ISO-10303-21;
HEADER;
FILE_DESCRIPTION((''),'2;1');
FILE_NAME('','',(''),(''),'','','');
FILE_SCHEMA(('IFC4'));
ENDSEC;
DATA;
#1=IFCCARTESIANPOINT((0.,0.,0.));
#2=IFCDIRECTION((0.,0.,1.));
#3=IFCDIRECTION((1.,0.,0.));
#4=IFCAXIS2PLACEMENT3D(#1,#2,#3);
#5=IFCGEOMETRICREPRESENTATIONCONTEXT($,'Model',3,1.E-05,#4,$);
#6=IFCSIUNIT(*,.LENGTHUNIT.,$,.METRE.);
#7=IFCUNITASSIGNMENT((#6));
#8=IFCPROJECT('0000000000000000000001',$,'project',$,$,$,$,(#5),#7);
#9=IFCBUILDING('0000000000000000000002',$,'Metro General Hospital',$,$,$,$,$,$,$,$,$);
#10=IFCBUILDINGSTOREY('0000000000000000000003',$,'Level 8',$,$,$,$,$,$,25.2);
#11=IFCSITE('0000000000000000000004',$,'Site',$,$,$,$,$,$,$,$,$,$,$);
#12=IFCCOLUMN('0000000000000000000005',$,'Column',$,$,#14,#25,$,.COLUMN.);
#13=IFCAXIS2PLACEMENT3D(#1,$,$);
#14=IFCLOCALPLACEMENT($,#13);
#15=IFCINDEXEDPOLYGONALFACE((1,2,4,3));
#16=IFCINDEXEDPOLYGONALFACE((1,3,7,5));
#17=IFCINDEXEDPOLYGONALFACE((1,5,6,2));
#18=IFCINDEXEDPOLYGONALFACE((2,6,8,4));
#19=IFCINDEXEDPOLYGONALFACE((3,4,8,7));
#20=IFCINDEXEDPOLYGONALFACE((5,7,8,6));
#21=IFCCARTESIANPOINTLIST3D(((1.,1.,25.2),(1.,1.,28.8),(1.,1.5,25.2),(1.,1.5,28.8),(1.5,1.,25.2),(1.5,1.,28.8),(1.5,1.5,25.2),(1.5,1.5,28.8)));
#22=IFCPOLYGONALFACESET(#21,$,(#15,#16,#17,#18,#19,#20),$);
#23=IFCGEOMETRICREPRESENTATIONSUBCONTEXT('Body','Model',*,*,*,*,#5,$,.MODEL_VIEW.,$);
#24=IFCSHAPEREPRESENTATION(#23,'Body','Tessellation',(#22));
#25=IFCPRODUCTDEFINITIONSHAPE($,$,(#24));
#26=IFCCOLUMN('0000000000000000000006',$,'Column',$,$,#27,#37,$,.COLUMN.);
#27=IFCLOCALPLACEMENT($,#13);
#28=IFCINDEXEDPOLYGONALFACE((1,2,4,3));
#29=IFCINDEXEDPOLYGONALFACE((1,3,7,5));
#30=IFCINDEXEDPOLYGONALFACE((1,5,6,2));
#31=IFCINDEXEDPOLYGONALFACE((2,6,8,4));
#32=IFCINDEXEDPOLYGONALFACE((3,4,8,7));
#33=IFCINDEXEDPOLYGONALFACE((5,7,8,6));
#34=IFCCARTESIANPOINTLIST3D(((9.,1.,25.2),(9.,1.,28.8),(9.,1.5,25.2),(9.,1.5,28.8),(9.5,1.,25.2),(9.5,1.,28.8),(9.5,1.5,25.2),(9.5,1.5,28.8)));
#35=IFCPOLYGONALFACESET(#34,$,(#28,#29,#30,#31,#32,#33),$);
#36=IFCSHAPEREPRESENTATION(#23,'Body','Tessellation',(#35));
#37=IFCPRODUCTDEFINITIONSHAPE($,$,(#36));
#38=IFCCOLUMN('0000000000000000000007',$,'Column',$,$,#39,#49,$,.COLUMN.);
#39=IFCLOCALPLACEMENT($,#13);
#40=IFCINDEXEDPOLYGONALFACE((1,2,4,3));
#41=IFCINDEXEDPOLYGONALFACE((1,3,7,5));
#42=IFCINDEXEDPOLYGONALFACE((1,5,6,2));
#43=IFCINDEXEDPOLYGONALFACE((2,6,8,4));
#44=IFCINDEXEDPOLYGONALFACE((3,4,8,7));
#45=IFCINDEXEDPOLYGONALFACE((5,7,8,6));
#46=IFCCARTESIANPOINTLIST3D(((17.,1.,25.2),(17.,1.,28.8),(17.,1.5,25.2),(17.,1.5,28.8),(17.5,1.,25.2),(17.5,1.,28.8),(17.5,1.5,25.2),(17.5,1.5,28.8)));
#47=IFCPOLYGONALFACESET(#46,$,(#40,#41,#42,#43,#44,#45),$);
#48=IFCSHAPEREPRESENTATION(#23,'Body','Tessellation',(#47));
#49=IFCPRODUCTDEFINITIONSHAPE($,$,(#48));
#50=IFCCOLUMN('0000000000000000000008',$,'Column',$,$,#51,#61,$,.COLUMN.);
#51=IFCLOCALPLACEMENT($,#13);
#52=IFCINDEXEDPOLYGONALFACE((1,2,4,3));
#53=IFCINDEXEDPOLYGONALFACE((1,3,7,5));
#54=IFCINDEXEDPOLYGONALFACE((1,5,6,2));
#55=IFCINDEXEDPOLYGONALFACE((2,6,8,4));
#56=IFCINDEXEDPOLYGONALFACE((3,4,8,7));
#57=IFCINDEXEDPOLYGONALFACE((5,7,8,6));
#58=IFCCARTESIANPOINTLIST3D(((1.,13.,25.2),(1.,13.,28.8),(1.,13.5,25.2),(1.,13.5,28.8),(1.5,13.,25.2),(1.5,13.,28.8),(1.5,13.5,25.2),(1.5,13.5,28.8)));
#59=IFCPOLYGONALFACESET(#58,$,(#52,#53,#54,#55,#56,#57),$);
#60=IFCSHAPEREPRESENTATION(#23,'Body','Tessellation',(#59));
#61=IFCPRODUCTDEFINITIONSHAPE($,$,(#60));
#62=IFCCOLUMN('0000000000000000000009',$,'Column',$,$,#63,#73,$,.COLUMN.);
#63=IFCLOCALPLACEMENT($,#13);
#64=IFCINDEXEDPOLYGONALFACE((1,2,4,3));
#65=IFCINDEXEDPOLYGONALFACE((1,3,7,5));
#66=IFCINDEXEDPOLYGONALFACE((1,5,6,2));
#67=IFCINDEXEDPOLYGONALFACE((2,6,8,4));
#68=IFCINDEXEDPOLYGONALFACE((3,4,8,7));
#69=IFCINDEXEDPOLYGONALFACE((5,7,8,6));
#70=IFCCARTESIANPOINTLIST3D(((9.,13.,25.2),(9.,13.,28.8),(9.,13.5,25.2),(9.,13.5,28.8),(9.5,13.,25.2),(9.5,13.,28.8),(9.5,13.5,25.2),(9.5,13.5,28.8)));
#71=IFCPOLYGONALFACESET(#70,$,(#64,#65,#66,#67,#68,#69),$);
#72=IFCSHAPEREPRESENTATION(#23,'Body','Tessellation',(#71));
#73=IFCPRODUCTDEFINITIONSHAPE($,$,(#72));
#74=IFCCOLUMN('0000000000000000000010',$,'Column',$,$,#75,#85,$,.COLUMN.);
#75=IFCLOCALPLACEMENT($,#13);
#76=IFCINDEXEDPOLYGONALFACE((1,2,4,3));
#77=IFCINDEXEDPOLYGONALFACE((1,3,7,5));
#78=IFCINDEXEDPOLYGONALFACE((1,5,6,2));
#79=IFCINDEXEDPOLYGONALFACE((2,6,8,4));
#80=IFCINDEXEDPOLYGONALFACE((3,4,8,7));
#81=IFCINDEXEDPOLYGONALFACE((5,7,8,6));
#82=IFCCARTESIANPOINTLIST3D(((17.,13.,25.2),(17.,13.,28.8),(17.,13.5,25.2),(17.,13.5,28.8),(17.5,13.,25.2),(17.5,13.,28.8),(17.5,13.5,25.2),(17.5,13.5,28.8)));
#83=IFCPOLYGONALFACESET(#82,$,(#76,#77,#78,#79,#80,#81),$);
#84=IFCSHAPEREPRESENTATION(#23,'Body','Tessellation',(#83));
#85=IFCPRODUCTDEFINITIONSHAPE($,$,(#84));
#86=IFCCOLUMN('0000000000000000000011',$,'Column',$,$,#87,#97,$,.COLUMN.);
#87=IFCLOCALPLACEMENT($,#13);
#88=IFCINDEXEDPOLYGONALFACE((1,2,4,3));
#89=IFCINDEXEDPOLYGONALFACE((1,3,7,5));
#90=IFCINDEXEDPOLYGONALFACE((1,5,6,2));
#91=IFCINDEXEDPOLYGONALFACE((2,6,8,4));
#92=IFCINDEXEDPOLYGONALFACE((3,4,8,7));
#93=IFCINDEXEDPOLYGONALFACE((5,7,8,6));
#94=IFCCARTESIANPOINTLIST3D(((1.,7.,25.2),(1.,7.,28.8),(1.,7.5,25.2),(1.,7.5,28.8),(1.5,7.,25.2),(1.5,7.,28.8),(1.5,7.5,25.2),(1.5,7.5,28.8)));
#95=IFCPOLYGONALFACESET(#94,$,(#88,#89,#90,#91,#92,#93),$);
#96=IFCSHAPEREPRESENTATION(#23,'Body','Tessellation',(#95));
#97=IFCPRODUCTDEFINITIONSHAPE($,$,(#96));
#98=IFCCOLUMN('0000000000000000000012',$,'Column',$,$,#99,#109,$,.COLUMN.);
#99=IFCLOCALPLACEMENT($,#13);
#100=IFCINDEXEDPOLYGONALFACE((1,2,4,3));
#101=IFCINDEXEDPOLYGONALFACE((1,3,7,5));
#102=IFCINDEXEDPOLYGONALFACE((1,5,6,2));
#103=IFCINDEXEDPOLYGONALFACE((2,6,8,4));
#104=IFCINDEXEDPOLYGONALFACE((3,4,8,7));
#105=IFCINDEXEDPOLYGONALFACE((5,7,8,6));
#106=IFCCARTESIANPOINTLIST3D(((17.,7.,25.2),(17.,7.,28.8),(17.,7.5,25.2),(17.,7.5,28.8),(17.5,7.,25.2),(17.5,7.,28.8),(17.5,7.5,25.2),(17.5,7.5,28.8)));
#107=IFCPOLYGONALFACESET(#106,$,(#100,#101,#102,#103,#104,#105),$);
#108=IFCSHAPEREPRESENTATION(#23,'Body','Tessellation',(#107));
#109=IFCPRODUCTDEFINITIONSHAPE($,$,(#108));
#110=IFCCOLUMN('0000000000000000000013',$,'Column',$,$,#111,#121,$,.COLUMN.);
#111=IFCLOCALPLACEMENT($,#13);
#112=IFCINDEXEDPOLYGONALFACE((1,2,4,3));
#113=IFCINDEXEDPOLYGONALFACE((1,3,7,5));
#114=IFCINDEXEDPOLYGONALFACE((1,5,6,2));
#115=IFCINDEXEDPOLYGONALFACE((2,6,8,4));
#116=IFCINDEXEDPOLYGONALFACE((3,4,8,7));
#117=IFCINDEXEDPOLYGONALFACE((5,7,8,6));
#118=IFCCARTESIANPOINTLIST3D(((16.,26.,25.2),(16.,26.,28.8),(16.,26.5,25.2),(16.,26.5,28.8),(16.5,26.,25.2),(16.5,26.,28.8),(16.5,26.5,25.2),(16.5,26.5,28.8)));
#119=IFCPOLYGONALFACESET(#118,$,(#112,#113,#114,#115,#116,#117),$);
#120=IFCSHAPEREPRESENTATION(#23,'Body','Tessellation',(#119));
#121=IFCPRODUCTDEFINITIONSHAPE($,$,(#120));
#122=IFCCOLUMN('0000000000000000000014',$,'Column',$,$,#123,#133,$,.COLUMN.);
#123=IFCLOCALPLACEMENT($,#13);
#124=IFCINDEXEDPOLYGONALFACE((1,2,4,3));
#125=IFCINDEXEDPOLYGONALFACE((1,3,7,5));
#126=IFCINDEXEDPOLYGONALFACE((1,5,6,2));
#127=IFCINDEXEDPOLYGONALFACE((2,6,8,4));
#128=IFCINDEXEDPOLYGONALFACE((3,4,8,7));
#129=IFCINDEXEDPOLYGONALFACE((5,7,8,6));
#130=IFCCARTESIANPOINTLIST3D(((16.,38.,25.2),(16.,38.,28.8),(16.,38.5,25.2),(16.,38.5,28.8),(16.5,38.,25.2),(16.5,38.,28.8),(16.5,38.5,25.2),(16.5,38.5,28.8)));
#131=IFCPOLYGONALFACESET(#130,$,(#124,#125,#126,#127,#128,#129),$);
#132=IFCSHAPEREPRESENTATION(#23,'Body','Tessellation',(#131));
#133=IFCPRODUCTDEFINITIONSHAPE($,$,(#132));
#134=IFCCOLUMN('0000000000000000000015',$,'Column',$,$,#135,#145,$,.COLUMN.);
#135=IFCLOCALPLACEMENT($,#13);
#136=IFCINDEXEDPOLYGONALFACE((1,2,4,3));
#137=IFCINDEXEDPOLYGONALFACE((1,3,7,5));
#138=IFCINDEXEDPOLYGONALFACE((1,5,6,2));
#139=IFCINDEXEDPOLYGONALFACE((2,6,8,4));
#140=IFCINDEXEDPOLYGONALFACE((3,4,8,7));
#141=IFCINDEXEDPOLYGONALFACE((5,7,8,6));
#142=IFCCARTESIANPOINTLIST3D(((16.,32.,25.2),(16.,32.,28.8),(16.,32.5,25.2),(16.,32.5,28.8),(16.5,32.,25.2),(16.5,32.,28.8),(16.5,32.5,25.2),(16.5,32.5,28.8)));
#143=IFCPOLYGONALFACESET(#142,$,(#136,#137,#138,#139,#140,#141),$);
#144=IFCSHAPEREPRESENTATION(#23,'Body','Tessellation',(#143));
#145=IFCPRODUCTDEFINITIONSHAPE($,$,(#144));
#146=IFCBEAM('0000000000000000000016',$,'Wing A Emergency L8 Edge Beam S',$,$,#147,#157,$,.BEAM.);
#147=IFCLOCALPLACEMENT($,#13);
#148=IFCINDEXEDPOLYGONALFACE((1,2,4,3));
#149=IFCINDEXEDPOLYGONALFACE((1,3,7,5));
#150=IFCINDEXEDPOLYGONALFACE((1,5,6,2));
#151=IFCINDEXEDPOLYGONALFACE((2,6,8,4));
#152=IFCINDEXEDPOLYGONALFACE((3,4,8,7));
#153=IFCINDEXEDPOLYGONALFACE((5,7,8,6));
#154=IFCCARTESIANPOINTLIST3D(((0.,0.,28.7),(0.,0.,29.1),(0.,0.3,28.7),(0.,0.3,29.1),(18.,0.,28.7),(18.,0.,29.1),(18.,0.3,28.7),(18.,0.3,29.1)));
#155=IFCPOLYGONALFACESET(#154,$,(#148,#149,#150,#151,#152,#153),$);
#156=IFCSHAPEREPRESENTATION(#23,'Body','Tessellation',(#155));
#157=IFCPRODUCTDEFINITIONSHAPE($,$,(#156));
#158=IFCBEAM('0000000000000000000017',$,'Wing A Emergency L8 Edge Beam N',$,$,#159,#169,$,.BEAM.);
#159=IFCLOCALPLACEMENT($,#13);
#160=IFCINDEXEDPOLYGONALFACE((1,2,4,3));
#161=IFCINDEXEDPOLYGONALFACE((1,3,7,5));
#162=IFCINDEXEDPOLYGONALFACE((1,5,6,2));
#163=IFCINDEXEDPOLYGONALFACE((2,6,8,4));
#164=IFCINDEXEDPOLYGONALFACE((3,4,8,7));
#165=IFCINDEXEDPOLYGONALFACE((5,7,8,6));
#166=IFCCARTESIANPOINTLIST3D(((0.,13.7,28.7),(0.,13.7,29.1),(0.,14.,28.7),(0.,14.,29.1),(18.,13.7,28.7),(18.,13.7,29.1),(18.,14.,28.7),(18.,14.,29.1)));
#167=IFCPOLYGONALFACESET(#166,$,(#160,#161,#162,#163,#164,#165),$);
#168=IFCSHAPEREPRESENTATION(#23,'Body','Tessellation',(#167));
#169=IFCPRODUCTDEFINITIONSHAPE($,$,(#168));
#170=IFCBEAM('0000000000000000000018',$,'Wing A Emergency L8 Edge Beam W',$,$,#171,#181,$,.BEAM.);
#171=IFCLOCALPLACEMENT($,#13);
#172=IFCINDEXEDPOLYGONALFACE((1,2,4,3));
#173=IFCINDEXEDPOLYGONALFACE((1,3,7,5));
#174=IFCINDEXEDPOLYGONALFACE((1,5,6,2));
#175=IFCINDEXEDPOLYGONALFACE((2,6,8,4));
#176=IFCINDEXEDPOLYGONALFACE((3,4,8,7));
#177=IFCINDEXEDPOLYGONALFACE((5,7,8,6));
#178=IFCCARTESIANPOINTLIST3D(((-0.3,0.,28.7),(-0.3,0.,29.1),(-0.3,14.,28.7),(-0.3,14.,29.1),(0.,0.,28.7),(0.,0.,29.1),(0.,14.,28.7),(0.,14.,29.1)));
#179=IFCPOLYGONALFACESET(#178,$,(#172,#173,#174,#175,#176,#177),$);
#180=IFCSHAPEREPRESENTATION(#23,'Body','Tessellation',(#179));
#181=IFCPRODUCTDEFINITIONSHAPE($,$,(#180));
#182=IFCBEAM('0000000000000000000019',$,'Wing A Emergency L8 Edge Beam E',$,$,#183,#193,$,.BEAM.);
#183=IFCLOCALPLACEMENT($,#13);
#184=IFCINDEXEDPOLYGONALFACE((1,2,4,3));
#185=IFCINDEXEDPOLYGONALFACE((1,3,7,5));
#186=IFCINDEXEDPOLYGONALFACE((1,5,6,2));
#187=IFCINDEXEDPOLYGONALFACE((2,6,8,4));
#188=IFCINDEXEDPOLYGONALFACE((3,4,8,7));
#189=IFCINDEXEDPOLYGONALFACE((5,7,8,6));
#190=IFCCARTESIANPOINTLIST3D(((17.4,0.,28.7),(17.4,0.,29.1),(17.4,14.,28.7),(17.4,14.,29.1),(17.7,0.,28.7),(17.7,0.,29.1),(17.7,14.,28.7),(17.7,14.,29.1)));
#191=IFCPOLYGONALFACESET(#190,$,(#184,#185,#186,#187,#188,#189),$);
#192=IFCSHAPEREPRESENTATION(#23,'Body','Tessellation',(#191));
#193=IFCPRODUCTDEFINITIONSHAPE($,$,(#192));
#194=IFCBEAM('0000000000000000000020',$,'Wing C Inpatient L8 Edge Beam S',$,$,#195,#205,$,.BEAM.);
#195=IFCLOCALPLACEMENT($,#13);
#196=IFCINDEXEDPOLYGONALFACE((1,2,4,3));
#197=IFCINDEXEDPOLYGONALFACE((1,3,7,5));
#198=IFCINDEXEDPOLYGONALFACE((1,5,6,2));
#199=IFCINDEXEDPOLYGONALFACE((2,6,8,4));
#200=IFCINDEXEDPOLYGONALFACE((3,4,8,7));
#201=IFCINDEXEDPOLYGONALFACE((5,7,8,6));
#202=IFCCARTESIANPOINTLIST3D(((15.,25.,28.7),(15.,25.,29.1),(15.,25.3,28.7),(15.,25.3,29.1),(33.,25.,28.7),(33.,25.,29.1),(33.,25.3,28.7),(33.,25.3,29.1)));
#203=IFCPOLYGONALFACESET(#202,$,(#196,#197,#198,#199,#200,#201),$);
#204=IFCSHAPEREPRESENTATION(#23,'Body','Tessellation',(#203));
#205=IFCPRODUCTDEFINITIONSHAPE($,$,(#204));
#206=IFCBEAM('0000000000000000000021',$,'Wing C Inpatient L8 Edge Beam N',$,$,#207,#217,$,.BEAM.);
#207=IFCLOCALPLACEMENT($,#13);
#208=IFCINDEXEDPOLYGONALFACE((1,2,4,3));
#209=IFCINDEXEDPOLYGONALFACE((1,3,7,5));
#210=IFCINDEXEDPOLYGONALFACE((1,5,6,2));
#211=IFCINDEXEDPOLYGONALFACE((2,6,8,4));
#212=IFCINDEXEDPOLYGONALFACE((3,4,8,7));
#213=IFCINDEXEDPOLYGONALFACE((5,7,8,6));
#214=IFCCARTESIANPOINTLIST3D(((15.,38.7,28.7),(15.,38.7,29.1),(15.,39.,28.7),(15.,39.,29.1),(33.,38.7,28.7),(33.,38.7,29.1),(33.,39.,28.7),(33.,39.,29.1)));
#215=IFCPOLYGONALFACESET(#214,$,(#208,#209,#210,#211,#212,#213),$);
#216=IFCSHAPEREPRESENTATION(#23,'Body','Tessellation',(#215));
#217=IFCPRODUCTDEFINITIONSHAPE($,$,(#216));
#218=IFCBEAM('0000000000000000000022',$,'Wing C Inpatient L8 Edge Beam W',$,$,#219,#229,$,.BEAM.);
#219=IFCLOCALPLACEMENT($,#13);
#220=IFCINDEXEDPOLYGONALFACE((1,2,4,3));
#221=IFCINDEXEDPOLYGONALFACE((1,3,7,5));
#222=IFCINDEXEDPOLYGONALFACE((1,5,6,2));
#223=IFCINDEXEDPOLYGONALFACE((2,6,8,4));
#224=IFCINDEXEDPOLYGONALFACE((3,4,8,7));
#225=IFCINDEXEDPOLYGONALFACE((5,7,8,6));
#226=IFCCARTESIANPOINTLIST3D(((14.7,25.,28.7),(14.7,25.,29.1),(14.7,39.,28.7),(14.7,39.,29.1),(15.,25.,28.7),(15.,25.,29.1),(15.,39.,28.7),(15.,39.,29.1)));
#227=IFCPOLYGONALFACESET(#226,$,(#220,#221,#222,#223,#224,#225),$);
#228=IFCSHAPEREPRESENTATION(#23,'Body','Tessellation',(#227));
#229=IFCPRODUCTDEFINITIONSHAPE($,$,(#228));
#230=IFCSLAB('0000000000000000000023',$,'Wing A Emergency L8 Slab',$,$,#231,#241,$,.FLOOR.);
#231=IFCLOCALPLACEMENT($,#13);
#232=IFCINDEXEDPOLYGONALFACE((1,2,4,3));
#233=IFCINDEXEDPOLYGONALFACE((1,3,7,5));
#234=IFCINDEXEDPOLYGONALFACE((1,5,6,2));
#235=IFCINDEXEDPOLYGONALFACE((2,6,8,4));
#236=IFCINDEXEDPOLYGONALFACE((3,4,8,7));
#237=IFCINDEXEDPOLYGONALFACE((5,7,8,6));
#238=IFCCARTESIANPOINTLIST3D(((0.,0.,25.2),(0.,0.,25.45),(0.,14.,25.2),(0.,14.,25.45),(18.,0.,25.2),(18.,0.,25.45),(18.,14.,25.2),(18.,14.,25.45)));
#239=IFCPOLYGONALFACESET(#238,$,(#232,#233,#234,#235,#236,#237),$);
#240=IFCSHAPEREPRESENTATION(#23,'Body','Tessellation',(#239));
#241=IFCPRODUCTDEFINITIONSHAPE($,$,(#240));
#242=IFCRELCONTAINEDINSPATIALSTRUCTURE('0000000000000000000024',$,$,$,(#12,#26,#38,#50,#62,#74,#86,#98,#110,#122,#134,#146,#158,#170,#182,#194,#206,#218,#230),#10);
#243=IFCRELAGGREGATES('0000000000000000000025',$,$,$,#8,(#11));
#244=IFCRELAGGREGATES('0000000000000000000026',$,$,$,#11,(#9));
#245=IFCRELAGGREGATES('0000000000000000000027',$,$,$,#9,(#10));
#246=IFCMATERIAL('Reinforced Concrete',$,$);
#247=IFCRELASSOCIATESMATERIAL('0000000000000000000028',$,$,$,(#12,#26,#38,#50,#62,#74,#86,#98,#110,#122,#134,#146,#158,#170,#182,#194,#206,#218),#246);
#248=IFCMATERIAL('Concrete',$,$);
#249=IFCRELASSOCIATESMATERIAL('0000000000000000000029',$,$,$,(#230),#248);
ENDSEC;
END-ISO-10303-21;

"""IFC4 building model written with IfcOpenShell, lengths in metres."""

from ifc_helpers import new_model, si_unit, frame, origin_with_axes, place, context, subcontext, project, spatial, line, indexed_curve, outline, extrude, material, element, save


model = new_model("IFC4")

# Units and contexts
model_context = context("Model", 3, precision=1e-05, world=origin_with_axes())
body_context = subcontext(model_context, "Body", "Model", "MODEL_VIEW")
ifc_project = project(units=[si_unit("LENGTHUNIT", "METRE")], contexts=[model_context])

# Site, building, storey
site = spatial("IfcSite", under=ifc_project, Name="Site")
building = spatial("IfcBuilding", under=site, Name="Metro General Hospital")
storey = spatial("IfcBuildingStorey", under=building, Name="Level 8", Elevation=25.2)

# Columns
ifc_material_1 = material(Name="Reinforced Concrete")
for number, where, z_axis, x_axis, name in (
    (1, (1.0, 1.0, 25.2), (0.0, 0.0, 1.0), (1.0, 0.0, 0.0), "Column"),
    (2, (9.0, 1.0, 25.2), (0.0, 0.0, 1.0), (1.0, 0.0, 0.0), "Column"),
    (3, (17.0, 1.0, 25.2), (0.0, 0.0, 1.0), (1.0, 0.0, 0.0), "Column"),
    (4, (1.0, 13.0, 25.2), (0.0, 0.0, 1.0), (1.0, 0.0, 0.0), "Column"),
    (5, (9.0, 13.0, 25.2), (0.0, 0.0, 1.0), (1.0, 0.0, 0.0), "Column"),
    (6, (17.0, 13.0, 25.2), (0.0, 0.0, 1.0), (1.0, 0.0, 0.0), "Column"),
    (7, (1.0, 7.0, 25.2), (0.0, 0.0, 1.0), (1.0, 0.0, 0.0), "Column"),
    (8, (17.0, 7.0, 25.2), (0.0, 0.0, 1.0), (1.0, 0.0, 0.0), "Column"),
    (9, (16.0, 26.0, 25.2), (0.0, 0.0, 1.0), (1.0, 0.0, 0.0), "Column"),
    (10, (16.0, 38.0, 25.2), (0.0, 0.0, 1.0), (1.0, 0.0, 0.0), "Column"),
    (11, (16.0, 32.0, 25.2), (0.0, 0.0, 1.0), (1.0, 0.0, 0.0), "Column"),
):
    element("IfcColumn", number, at=place(None, frame(where, z_axis=z_axis, x_axis=x_axis)), inside=storey, material=ifc_material_1, Name=name, PredefinedType="COLUMN", context=body_context, shape_type="SweptSolid", body=[
        extrude(outline(indexed_curve([(0.0, 0.0), (0.5, 0.0), (0.5, 0.5), (0.0, 0.5)], segments=[line(1, 2, 3, 4, 1)])), origin_with_axes(), (0.0, 0.0, 1.0), 3.6),
    ])

# Beams
for number, where, z_axis, x_axis, name in (
    (12, (0.0, 0.0, 28.7), (0.0, 0.0, 1.0), (1.0, 0.0, 0.0), "Wing A Emergency L8 Edge Beam S"),
    (13, (0.0, 13.7, 28.7), (0.0, 0.0, 1.0), (1.0, 0.0, 0.0), "Wing A Emergency L8 Edge Beam N"),
):
    element("IfcBeam", number, at=place(None, frame(where, z_axis=z_axis, x_axis=x_axis)), inside=storey, material=ifc_material_1, Name=name, PredefinedType="BEAM", context=body_context, shape_type="SweptSolid", body=[
        extrude(outline(indexed_curve([(0.0, 0.0), (18.0, 0.0), (18.0, 0.3), (0.0, 0.3)], segments=[line(1, 2, 3, 4, 1)])), origin_with_axes(), (0.0, 0.0, 1.0), 0.4),
    ])
for number, where, z_axis, x_axis, name in (
    (14, (0.0, 0.0, 28.7), (0.0, 0.0, 1.0), (0.0, 1.0, 0.0), "Wing A Emergency L8 Edge Beam W"),
    (15, (17.7, 0.0, 28.7), (0.0, 0.0, 1.0), (0.0, 1.0, 0.0), "Wing A Emergency L8 Edge Beam E"),
):
    element("IfcBeam", number, at=place(None, frame(where, z_axis=z_axis, x_axis=x_axis)), inside=storey, material=ifc_material_1, Name=name, PredefinedType="BEAM", context=body_context, shape_type="SweptSolid", body=[
        extrude(outline(indexed_curve([(0.0, 0.0), (14.0, 0.0), (14.0, 0.3), (0.0, 0.3)], segments=[line(1, 2, 3, 4, 1)])), origin_with_axes(), (0.0, 0.0, 1.0), 0.4),
    ])
for number, where, z_axis, x_axis, name in (
    (16, (15.0, 25.0, 28.7), (0.0, 0.0, 1.0), (1.0, 0.0, 0.0), "Wing C Inpatient L8 Edge Beam S"),
    (17, (15.0, 38.7, 28.7), (0.0, 0.0, 1.0), (1.0, 0.0, 0.0), "Wing C Inpatient L8 Edge Beam N"),
):
    element("IfcBeam", number, at=place(None, frame(where, z_axis=z_axis, x_axis=x_axis)), inside=storey, material=ifc_material_1, Name=name, PredefinedType="BEAM", context=body_context, shape_type="SweptSolid", body=[
        extrude(outline(indexed_curve([(0.0, 0.0), (18.0, 0.0), (18.0, 0.3), (0.0, 0.3)], segments=[line(1, 2, 3, 4, 1)])), origin_with_axes(), (0.0, 0.0, 1.0), 0.4),
    ])
beam_placement = place(None, frame((15.0, 25.0, 28.7), z_axis=(0.0, 0.0, 1.0), x_axis=(0.0, 1.0, 0.0)))
element("IfcBeam", 18, at=beam_placement, inside=storey, material=ifc_material_1, Name="Wing C Inpatient L8 Edge Beam W", PredefinedType="BEAM", context=body_context, shape_type="SweptSolid", body=[
    extrude(outline(indexed_curve([(0.0, 0.0), (14.0, 0.0), (14.0, 0.3), (0.0, 0.3)], segments=[line(1, 2, 3, 4, 1)])), origin_with_axes(), (0.0, 0.0, 1.0), 0.4),
])

# Slab
ifc_material_2 = material(Name="Concrete")
for number, where, z_axis, x_axis, name in (
    (19, (0.0, 0.0, 25.2), (0.0, 0.0, 1.0), (1.0, 0.0, 0.0), "Wing A Emergency L8 Slab"),
):
    element("IfcSlab", number, at=place(None, frame(where, z_axis=z_axis, x_axis=x_axis)), inside=storey, material=ifc_material_2, Name=name, PredefinedType="FLOOR", context=body_context, shape_type="SweptSolid", body=[
        extrude(outline(indexed_curve([(0.0, 0.0), (18.0, 0.0), (18.0, 14.0), (0.0, 14.0)], segments=[line(1, 2, 3, 4, 1)])), origin_with_axes(), (0.0, 0.0, 1.0), 0.25),
    ])

save(model, "model.ifc")
